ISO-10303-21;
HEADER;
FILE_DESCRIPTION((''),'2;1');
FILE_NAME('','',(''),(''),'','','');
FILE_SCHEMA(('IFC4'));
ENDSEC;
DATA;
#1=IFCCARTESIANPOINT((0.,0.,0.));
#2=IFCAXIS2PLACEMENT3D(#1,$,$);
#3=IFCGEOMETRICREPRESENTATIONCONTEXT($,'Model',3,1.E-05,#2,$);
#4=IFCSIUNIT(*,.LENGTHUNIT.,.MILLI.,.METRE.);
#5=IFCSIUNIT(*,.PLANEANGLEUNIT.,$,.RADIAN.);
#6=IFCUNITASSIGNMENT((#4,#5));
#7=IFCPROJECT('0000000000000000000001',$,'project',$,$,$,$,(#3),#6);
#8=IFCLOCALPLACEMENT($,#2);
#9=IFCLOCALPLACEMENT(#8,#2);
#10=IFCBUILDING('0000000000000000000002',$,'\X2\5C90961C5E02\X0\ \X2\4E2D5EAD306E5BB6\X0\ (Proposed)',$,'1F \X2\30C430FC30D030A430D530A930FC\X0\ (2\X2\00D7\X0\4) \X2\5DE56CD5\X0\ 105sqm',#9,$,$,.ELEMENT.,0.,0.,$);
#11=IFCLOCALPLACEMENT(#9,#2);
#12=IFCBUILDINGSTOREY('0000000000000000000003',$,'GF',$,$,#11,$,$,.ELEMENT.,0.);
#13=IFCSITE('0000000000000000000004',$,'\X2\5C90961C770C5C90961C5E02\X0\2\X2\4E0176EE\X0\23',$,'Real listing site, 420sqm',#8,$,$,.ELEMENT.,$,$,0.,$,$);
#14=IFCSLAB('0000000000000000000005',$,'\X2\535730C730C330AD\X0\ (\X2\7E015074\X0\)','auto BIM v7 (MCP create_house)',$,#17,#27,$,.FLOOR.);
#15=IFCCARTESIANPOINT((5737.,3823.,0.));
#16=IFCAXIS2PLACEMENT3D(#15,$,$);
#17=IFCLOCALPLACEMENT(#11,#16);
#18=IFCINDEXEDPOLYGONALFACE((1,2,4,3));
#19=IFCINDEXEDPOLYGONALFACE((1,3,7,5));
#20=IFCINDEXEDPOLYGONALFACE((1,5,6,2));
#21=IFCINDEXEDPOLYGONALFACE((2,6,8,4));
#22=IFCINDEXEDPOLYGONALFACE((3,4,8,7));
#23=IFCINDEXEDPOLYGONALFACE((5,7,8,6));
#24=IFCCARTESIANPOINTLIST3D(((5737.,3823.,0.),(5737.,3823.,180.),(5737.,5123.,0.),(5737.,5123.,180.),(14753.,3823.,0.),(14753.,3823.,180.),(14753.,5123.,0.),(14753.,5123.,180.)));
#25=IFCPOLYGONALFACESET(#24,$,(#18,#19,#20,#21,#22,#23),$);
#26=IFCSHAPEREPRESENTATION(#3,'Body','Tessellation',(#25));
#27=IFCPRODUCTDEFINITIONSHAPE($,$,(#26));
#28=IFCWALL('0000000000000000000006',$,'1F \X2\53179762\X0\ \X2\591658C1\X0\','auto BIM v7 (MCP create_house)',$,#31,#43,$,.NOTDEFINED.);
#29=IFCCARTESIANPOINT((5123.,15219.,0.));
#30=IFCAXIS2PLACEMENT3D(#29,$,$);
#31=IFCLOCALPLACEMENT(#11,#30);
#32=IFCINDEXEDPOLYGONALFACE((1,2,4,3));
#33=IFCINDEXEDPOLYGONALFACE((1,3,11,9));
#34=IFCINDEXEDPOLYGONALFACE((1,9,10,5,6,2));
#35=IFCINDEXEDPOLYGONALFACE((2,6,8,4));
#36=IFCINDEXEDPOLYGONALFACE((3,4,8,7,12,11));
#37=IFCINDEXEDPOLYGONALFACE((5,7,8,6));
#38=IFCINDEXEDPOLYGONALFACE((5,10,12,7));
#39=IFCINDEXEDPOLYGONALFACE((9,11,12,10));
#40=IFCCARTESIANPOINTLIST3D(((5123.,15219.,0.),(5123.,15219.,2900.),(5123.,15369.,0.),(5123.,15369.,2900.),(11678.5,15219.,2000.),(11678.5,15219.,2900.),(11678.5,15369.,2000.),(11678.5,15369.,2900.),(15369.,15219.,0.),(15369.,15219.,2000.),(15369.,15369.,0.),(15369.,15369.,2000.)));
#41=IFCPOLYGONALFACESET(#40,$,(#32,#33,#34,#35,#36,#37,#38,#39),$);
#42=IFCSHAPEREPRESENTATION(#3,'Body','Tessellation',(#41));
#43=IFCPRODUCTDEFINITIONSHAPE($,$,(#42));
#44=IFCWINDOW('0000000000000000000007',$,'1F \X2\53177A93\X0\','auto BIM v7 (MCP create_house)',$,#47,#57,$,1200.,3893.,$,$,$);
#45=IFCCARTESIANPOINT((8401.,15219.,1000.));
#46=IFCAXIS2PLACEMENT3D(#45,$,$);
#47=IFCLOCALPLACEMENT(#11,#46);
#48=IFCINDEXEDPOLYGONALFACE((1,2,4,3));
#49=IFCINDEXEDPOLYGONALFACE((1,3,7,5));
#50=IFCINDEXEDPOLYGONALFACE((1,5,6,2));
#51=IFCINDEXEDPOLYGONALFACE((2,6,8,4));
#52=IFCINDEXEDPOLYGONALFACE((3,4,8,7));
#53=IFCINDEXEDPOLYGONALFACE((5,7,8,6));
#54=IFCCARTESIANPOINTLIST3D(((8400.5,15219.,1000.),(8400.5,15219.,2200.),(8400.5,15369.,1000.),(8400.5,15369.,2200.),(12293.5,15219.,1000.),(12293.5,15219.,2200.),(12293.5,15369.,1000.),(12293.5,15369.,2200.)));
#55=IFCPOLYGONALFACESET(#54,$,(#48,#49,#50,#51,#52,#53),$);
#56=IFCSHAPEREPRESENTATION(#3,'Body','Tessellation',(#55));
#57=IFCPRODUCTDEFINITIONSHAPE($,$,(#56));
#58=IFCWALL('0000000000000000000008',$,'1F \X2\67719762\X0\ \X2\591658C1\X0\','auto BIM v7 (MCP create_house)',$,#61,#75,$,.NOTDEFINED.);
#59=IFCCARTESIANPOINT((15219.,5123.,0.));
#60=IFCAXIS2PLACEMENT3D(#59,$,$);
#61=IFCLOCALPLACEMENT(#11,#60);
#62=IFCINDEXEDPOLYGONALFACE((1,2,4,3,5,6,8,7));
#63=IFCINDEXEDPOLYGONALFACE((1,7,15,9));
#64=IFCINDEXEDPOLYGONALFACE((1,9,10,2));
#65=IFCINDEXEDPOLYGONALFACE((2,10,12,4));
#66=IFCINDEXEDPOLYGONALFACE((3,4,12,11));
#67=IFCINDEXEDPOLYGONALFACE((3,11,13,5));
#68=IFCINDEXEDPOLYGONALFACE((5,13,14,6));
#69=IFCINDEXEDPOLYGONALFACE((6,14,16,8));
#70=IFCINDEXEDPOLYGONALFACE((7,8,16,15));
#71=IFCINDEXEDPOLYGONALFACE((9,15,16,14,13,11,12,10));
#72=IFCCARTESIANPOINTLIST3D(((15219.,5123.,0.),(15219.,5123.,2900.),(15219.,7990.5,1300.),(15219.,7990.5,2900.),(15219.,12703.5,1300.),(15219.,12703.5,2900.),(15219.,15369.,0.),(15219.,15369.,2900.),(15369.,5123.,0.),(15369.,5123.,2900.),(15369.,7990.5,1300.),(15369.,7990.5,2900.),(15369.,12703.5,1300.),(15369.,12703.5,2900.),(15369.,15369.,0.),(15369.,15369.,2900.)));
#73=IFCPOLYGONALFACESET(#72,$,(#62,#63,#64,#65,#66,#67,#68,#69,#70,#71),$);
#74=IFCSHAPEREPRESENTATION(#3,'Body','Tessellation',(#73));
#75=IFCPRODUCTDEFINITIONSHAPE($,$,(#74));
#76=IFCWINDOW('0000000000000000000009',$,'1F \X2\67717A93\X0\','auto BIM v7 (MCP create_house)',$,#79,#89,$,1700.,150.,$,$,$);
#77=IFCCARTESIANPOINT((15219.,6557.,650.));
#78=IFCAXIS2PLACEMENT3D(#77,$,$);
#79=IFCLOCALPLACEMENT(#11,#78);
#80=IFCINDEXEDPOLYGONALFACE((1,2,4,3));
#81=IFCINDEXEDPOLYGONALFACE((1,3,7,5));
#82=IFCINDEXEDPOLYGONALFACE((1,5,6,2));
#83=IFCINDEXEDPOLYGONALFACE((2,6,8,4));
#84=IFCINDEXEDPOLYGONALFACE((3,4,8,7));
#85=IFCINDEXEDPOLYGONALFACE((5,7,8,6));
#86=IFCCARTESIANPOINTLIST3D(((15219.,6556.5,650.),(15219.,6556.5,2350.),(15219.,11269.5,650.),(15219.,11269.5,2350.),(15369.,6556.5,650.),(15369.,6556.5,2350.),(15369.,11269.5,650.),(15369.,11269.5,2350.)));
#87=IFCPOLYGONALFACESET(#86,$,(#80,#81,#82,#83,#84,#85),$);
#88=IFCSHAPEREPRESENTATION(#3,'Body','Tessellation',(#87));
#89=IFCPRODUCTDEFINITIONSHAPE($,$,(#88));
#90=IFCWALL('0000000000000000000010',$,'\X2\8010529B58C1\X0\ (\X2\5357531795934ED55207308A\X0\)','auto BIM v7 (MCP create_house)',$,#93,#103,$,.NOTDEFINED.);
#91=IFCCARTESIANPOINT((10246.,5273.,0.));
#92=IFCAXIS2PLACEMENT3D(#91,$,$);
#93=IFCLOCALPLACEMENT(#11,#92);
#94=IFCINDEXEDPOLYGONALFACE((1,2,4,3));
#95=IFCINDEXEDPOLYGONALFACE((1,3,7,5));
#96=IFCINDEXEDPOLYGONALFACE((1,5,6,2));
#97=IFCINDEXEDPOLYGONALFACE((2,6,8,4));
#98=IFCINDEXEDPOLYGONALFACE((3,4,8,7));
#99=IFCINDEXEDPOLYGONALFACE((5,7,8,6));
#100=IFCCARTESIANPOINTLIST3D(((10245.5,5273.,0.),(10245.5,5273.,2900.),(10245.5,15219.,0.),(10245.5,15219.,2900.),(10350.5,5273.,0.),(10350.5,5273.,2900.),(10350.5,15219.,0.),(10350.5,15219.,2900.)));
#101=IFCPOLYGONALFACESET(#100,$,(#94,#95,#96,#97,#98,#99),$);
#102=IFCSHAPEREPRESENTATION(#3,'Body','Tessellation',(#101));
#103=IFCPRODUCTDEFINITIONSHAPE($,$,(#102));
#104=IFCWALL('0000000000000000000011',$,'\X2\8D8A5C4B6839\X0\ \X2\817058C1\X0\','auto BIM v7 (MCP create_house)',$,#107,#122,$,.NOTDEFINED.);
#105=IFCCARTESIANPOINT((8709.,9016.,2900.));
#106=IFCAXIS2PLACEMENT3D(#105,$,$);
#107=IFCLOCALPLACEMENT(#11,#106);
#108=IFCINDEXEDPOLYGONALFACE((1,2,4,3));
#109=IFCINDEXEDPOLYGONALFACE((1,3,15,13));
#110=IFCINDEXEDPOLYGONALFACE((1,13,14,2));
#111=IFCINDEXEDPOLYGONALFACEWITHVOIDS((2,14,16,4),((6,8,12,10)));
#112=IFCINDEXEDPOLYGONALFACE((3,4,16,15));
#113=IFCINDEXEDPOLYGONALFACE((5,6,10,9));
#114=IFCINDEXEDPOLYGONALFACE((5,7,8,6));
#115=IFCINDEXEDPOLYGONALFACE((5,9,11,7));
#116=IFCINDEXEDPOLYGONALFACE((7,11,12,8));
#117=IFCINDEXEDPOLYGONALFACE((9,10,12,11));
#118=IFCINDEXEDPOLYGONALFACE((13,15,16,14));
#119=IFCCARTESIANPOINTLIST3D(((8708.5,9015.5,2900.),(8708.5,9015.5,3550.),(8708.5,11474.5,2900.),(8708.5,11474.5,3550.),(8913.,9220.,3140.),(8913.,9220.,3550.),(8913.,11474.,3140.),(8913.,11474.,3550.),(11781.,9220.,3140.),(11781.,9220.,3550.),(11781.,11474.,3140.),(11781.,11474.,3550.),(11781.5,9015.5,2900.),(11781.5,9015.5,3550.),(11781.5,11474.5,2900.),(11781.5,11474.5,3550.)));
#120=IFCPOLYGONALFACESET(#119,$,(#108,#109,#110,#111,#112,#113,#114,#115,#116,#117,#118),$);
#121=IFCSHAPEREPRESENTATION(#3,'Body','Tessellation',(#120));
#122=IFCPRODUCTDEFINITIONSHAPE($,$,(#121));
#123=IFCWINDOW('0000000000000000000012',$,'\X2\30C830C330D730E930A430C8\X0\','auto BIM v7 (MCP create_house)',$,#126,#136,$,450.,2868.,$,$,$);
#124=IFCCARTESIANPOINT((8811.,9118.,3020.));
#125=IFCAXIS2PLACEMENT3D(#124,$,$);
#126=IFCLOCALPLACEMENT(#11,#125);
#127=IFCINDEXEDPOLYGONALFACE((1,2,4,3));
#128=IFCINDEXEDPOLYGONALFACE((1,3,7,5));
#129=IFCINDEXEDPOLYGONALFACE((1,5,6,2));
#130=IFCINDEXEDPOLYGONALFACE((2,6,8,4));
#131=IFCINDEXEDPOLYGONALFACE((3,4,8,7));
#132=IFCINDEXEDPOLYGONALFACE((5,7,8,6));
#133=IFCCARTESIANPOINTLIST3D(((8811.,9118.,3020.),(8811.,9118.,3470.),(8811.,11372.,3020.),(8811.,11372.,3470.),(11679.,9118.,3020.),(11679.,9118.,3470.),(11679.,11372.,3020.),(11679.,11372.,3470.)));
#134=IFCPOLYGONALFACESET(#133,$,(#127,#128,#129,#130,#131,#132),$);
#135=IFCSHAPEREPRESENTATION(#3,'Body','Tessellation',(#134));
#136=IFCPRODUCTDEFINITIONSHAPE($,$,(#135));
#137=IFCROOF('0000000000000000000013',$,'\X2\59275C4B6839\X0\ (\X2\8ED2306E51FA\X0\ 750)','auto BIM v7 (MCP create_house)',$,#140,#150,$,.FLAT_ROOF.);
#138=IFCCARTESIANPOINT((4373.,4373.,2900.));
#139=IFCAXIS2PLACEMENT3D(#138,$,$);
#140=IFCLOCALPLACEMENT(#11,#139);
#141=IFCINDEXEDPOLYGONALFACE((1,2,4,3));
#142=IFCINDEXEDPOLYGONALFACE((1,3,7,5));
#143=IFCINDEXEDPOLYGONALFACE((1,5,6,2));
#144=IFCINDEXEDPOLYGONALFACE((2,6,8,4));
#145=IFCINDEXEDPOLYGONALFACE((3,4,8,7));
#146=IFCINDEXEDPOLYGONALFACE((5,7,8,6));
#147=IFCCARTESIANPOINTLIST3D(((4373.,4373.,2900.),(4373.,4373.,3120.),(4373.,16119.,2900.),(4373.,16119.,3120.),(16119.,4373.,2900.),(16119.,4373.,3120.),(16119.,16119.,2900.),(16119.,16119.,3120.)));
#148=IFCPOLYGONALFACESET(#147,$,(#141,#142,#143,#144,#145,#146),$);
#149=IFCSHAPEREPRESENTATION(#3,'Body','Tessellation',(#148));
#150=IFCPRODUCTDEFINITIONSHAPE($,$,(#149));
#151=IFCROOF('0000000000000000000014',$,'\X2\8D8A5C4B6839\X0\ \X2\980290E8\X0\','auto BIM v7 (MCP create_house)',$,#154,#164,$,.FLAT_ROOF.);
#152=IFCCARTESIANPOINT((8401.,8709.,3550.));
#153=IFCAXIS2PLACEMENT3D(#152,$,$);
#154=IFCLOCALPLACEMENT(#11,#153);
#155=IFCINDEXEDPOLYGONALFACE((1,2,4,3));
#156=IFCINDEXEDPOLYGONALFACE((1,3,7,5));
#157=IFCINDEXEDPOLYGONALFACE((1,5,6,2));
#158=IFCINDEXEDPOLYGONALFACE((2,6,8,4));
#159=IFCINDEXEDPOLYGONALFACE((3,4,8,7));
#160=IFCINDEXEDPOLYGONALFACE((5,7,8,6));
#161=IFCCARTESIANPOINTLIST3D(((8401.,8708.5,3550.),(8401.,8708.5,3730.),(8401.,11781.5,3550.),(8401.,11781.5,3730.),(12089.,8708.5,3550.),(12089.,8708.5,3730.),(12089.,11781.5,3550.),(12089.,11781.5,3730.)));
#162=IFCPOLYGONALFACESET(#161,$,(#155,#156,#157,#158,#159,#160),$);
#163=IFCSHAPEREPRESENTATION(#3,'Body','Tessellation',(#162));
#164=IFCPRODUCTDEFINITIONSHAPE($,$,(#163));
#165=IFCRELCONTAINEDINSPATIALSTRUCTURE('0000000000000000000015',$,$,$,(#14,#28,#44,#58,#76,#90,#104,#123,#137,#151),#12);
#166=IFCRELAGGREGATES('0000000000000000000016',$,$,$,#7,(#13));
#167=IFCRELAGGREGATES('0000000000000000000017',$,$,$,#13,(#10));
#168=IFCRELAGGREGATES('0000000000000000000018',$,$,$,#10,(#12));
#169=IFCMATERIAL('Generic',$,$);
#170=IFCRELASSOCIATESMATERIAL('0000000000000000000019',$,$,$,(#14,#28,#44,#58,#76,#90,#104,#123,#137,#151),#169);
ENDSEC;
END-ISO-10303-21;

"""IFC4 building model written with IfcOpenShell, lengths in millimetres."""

from ifc_helpers import new_model, si_unit, frame, frame_2d, origin, place, context, project, spatial, rectangle, extrude, material, element, fill, save


model = new_model("IFC4")

# Units and contexts
model_context = context("Model", 3, precision=1e-05, world=origin())
ifc_project = project(units=[si_unit("LENGTHUNIT", "METRE", prefix="MILLI"), si_unit("PLANEANGLEUNIT", "RADIAN")], contexts=[model_context])

# Site, building, storey
site_placement = place(None, origin())
site = spatial("IfcSite", under=ifc_project, at=site_placement, Name="岐阜県岐阜市2丁目23", ObjectType="Real listing site, 420sqm", CompositionType="ELEMENT", RefElevation=0.0)
building_placement = place(site_placement, origin())
building = spatial("IfcBuilding", under=site, at=building_placement, Name="岐阜市 中庭の家 (Proposed)", ObjectType="1F ツーバイフォー (2×4) 工法 105sqm", CompositionType="ELEMENT", ElevationOfRefHeight=0.0, ElevationOfTerrain=0.0)
storey_placement = place(building_placement, origin())
storey = spatial("IfcBuildingStorey", under=building, at=storey_placement, Name="GF", CompositionType="ELEMENT", Elevation=0.0)

# Slab
ifc_material = material(Name="Generic")
slab_1_placement = place(storey_placement, frame((5737.0, 3823.0, 0.0)))
element("IfcSlab", 1, at=slab_1_placement, inside=storey, material=ifc_material, Name="南デッキ (縁側)", Description="auto BIM v7 (MCP create_house)", PredefinedType="FLOOR", context=model_context, shape_type="SweptSolid", body=[
    extrude(rectangle(XDim=9016.0, YDim=1300.0, at=frame_2d((4508.0, 650.0))), frame((5737.0, 3823.0, 0.0)), (0.0, 0.0, 1.0), 180.0),
])

# Walls, openings, windows
wall_1_placement = place(storey_placement, frame((5123.0, 15219.0, 0.0)))
wall_1 = element("IfcWall", 2, at=wall_1_placement, inside=storey, material=ifc_material, Name="1F 北面 外壁", Description="auto BIM v7 (MCP create_house)", PredefinedType="NOTDEFINED", context=model_context, shape_type="SweptSolid", body=[
    extrude(rectangle(XDim=10246.0, YDim=150.0, at=frame_2d((5123.0, 75.0))), frame((5123.0, 15219.0, 0.0)), (0.0, 0.0, 1.0), 2900.0),
])
opening_1_placement = place(storey_placement, frame((8401.0, 15219.0, 1000.0)))
opening_1 = element("IfcOpeningElement", 3, at=opening_1_placement, cuts=wall_1, PredefinedType="NOTDEFINED", context=model_context, shape_type="SweptSolid", body=[
    extrude(rectangle(XDim=3893.0, YDim=150.0, at=frame_2d((1946.0, 75.0))), frame((8401.0, 15219.0, 1000.0)), (0.0, 0.0, 1.0), 1200.0),
])
window_1_placement = place(storey_placement, frame((8401.0, 15219.0, 1000.0)))
window_1 = element("IfcWindow", 4, at=window_1_placement, inside=storey, material=ifc_material, Name="1F 北窓", Description="auto BIM v7 (MCP create_house)", OverallHeight=1200.0, OverallWidth=3893.0, context=model_context, shape_type="SweptSolid", body=[
    extrude(rectangle(XDim=3893.0, YDim=150.0, at=frame_2d((1946.0, 75.0))), frame((8401.0, 15219.0, 1000.0)), (0.0, 0.0, 1.0), 1200.0),
])
fill(opening_1, window_1)
wall_2_placement = place(storey_placement, frame((15219.0, 5123.0, 0.0)))
wall_2 = element("IfcWall", 5, at=wall_2_placement, inside=storey, material=ifc_material, Name="1F 東面 外壁", Description="auto BIM v7 (MCP create_house)", PredefinedType="NOTDEFINED", context=model_context, shape_type="SweptSolid", body=[
    extrude(rectangle(XDim=150.0, YDim=10246.0, at=frame_2d((75.0, 5123.0))), frame((15219.0, 5123.0, 0.0)), (0.0, 0.0, 1.0), 2900.0),
])
opening_2_placement = place(storey_placement, frame((15219.0, 6557.0, 650.0)))
opening_2 = element("IfcOpeningElement", 6, at=opening_2_placement, cuts=wall_2, PredefinedType="NOTDEFINED", context=model_context, shape_type="SweptSolid", body=[
    extrude(rectangle(XDim=150.0, YDim=4713.0, at=frame_2d((75.0, 2356.0))), frame((15219.0, 6557.0, 650.0)), (0.0, 0.0, 1.0), 1700.0),
])
window_2_placement = place(storey_placement, frame((15219.0, 6557.0, 650.0)))
window_2 = element("IfcWindow", 7, at=window_2_placement, inside=storey, material=ifc_material, Name="1F 東窓", Description="auto BIM v7 (MCP create_house)", OverallHeight=1700.0, OverallWidth=150.0, context=model_context, shape_type="SweptSolid", body=[
    extrude(rectangle(XDim=150.0, YDim=4713.0, at=frame_2d((75.0, 2356.0))), frame((15219.0, 6557.0, 650.0)), (0.0, 0.0, 1.0), 1700.0),
])
fill(opening_2, window_2)

# Wall
wall_3_placement = place(storey_placement, frame((10246.0, 5273.0, 0.0)))
element("IfcWall", 8, at=wall_3_placement, inside=storey, material=ifc_material, Name="耐力壁 (南北間仕切り)", Description="auto BIM v7 (MCP create_house)", PredefinedType="NOTDEFINED", context=model_context, shape_type="SweptSolid", body=[
    extrude(rectangle(XDim=105.0, YDim=9946.0, at=frame_2d((52.0, 4973.0))), frame((10246.0, 5273.0, 0.0)), (0.0, 0.0, 1.0), 2900.0),
])

# Wall, opening, window
wall_4_placement = place(storey_placement, frame((8709.0, 9016.0, 2900.0)))
wall_4 = element("IfcWall", 9, at=wall_4_placement, inside=storey, material=ifc_material, Name="越屋根 腰壁", Description="auto BIM v7 (MCP create_house)", PredefinedType="NOTDEFINED", context=model_context, shape_type="SweptSolid", body=[
    extrude(rectangle(XDim=3073.0, YDim=2459.0, at=frame_2d((1536.0, 1229.0))), frame((8709.0, 9016.0, 2900.0)), (0.0, 0.0, 1.0), 650.0),
])
opening_3_placement = place(storey_placement, frame((8811.0, 9118.0, 3020.0)))
opening_3 = element("IfcOpeningElement", 10, at=opening_3_placement, cuts=wall_4, PredefinedType="NOTDEFINED", context=model_context, shape_type="SweptSolid", body=[
    extrude(rectangle(XDim=2868.0, YDim=2254.0, at=frame_2d((1434.0, 1127.0))), frame((8811.0, 9118.0, 3020.0)), (0.0, 0.0, 1.0), 450.0),
])
window_3_placement = place(storey_placement, frame((8811.0, 9118.0, 3020.0)))
window_3 = element("IfcWindow", 11, at=window_3_placement, inside=storey, material=ifc_material, Name="トップライト", Description="auto BIM v7 (MCP create_house)", OverallHeight=450.0, OverallWidth=2868.0, context=model_context, shape_type="SweptSolid", body=[
    extrude(rectangle(XDim=2868.0, YDim=2254.0, at=frame_2d((1434.0, 1127.0))), frame((8811.0, 9118.0, 3020.0)), (0.0, 0.0, 1.0), 450.0),
])
fill(opening_3, window_3)

# Roofs
roof_1_placement = place(storey_placement, frame((4373.0, 4373.0, 2900.0)))
element("IfcRoof", 12, at=roof_1_placement, inside=storey, material=ifc_material, Name="大屋根 (軒の出 750)", Description="auto BIM v7 (MCP create_house)", PredefinedType="FLAT_ROOF", context=model_context, shape_type="SweptSolid", body=[
    extrude(rectangle(XDim=11746.0, YDim=11746.0, at=frame_2d((5873.0, 5873.0))), frame((4373.0, 4373.0, 2900.0)), (0.0, 0.0, 1.0), 220.0),
])
roof_2_placement = place(storey_placement, frame((8401.0, 8709.0, 3550.0)))
element("IfcRoof", 13, at=roof_2_placement, inside=storey, material=ifc_material, Name="越屋根 頂部", Description="auto BIM v7 (MCP create_house)", PredefinedType="FLAT_ROOF", context=model_context, shape_type="SweptSolid", body=[
    extrude(rectangle(XDim=3688.0, YDim=3073.0, at=frame_2d((1844.0, 1536.0))), frame((8401.0, 8709.0, 3550.0)), (0.0, 0.0, 1.0), 180.0),
])

save(model, "model.ifc")
